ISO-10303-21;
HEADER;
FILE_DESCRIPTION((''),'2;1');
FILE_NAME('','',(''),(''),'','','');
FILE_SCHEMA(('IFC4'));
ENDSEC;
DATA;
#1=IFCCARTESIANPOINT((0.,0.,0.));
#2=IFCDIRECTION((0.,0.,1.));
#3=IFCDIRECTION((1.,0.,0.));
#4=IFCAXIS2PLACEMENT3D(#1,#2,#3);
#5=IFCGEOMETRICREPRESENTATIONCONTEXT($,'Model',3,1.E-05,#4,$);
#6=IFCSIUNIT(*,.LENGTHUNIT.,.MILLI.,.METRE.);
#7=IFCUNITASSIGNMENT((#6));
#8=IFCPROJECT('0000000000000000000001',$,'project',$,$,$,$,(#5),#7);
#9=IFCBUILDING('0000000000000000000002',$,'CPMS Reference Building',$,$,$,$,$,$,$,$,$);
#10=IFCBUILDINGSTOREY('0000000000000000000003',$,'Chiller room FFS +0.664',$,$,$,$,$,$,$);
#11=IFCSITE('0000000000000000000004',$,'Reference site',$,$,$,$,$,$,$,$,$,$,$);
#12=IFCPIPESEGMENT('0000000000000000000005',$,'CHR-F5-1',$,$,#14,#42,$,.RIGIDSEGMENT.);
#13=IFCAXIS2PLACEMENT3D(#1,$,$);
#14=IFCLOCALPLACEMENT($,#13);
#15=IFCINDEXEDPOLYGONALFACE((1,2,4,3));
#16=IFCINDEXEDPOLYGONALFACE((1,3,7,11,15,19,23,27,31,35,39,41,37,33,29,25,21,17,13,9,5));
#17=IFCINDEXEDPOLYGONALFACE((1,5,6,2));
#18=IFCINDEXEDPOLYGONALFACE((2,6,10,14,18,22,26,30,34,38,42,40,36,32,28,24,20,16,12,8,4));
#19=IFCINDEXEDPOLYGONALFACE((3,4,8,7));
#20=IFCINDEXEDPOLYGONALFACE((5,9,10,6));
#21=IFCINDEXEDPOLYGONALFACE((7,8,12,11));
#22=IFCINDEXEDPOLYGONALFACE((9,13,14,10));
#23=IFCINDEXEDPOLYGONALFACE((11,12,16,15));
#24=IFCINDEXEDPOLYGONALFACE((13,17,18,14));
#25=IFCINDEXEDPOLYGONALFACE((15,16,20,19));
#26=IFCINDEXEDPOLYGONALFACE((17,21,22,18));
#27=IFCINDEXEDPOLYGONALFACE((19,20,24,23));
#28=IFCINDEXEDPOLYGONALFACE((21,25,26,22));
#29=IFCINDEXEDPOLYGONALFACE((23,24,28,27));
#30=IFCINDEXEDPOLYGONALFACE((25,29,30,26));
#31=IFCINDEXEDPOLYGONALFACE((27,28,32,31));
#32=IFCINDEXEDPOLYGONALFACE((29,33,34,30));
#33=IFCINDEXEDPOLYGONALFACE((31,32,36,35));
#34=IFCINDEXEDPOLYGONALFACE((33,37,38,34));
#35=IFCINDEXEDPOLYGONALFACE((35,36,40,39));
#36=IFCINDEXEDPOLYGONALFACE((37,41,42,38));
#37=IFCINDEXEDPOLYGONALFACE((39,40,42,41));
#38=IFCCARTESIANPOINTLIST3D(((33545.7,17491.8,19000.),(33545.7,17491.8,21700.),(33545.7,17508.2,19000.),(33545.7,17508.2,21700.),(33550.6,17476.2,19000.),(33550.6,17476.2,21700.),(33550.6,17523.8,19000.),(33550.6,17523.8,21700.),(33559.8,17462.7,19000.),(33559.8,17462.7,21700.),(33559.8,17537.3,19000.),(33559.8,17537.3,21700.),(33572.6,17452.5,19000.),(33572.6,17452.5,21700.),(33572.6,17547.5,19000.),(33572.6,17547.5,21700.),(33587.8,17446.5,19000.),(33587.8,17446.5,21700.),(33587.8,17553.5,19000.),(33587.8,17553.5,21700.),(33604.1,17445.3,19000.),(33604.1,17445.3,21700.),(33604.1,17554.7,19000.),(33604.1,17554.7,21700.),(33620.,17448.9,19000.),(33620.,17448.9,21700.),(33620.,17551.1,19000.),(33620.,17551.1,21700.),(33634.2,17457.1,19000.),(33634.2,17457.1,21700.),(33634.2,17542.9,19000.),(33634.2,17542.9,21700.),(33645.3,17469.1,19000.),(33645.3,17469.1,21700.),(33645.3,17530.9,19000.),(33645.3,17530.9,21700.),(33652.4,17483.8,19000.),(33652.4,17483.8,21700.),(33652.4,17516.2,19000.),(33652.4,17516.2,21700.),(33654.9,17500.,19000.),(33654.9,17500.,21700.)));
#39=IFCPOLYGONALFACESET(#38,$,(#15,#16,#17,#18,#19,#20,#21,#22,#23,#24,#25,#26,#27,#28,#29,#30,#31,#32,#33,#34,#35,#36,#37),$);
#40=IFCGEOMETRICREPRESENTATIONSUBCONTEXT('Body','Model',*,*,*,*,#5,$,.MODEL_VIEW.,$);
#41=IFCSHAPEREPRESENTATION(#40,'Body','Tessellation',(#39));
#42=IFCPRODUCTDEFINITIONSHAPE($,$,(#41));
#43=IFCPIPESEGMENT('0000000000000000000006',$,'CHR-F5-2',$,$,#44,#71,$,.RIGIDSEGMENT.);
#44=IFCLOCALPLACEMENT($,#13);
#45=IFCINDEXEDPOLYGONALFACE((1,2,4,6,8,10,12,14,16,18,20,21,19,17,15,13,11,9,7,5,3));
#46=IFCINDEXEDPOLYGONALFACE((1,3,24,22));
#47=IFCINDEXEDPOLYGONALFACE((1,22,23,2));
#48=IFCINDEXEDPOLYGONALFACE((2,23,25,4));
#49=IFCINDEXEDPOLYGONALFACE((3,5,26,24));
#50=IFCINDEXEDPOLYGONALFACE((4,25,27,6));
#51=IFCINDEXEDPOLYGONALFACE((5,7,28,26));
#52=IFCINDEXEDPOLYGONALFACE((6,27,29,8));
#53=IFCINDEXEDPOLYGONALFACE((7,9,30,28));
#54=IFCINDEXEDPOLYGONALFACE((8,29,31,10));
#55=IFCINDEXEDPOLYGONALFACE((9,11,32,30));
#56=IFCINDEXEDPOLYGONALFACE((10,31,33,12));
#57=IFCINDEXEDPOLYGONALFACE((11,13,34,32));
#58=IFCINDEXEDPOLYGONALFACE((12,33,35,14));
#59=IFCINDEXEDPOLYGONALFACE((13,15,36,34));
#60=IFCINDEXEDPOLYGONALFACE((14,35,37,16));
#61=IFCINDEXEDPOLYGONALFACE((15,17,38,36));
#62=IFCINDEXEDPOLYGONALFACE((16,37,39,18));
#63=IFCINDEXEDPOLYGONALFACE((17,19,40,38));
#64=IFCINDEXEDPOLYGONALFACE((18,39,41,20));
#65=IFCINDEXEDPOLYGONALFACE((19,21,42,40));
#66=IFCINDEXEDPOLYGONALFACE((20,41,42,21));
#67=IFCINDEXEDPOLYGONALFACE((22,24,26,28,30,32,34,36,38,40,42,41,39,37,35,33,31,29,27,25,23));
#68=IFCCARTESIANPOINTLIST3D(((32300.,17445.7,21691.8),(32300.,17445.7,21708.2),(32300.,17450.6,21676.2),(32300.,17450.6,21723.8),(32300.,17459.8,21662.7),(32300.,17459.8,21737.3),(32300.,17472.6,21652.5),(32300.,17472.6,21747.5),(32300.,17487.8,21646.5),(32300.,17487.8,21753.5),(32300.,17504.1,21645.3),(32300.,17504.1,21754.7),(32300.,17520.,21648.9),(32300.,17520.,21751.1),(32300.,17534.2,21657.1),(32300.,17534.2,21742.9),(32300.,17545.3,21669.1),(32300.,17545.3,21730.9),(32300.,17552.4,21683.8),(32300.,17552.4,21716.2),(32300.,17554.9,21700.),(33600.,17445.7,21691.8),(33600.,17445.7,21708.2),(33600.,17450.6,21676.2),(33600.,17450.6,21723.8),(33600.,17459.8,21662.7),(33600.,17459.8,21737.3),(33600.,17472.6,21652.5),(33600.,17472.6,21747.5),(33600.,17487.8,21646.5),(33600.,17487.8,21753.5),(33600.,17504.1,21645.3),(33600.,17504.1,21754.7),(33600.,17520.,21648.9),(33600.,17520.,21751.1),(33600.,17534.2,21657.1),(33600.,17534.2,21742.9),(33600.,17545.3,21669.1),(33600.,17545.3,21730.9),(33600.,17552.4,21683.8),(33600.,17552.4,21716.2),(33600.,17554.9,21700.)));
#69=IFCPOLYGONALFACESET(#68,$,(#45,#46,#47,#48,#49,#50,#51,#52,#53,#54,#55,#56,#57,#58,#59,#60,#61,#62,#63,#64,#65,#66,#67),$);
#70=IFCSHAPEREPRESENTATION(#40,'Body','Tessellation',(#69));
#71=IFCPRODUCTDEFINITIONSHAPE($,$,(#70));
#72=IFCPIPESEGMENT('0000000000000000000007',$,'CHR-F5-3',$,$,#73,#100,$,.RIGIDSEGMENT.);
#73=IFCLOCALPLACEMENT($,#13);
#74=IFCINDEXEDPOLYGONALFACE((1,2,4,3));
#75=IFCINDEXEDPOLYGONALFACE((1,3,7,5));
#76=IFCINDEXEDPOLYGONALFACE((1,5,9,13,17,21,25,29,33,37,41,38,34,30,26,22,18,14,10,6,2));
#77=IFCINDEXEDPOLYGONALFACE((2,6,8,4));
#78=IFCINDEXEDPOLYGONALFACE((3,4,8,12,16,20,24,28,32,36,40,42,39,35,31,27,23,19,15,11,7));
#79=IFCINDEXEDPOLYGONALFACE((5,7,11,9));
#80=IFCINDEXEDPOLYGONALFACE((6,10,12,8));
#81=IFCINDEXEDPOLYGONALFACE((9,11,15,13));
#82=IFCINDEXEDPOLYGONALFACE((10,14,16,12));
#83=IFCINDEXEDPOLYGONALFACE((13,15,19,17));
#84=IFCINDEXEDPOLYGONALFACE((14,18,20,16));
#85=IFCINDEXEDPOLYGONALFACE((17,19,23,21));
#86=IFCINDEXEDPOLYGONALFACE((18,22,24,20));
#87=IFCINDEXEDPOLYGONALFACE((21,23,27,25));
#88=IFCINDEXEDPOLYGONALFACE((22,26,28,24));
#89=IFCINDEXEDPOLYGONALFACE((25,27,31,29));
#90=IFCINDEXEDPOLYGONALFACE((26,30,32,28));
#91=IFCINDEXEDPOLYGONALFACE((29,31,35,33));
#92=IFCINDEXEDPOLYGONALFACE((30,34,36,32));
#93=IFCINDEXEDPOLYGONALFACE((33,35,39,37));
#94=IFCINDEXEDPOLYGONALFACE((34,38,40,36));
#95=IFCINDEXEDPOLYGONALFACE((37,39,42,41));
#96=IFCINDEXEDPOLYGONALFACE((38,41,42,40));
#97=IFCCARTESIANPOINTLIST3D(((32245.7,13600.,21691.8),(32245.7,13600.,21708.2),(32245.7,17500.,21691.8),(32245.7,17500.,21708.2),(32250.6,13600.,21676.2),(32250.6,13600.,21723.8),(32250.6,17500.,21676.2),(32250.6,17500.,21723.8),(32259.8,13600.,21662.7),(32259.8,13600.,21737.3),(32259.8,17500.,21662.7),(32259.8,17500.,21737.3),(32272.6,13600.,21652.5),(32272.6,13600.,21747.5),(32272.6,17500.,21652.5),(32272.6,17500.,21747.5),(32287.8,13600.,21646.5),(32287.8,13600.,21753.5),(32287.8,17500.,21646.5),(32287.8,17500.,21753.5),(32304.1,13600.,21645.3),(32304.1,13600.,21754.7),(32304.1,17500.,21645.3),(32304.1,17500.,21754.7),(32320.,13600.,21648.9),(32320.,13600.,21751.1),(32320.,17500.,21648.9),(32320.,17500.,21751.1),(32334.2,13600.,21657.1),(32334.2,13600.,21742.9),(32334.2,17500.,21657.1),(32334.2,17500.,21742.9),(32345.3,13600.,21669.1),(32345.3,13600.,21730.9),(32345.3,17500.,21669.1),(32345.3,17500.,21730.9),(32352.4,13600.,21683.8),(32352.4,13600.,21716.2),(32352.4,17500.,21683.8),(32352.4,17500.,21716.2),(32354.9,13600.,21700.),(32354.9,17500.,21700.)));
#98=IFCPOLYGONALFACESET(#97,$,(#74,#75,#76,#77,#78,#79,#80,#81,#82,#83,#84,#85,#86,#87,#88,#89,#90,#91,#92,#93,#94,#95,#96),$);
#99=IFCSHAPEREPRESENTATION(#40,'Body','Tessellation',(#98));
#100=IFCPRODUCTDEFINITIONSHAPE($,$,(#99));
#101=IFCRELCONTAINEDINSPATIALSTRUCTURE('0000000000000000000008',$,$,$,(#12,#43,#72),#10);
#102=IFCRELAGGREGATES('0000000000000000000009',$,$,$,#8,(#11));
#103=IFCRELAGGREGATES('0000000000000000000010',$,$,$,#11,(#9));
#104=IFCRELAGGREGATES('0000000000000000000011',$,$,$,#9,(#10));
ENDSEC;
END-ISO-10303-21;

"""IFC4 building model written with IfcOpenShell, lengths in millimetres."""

from ifc_helpers import new_model, si_unit, frame, origin_with_axes, origin_2d, place, context, subcontext, project, spatial, circle_curve, outline, extrude, element, save


model = new_model("IFC4")

# Units and contexts
model_context = context("Model", 3, precision=1e-05, world=origin_with_axes())
body_context = subcontext(model_context, "Body", "Model", "MODEL_VIEW")
ifc_project = project(units=[si_unit("LENGTHUNIT", "METRE", prefix="MILLI")], contexts=[model_context])

# Site, building, storey
site = spatial("IfcSite", under=ifc_project, Name="Reference site")
building = spatial("IfcBuilding", under=site, Name="CPMS Reference Building")
storey = spatial("IfcBuildingStorey", under=building, Name="Chiller room FFS +0.664")

# Pipe segments
pipe_segment_1_placement = place(None, origin_with_axes())
element("IfcPipeSegment", 1, at=pipe_segment_1_placement, inside=storey, Name="CHR-F5-1", PredefinedType="RIGIDSEGMENT", context=body_context, shape_type="SweptSolid", body=[
    extrude(outline(circle_curve(origin_2d(), 54.9)), frame((33600.0, 17500.0, 19000.0), z_axis=(0.0, 0.0, 1.0), x_axis=(1.0, 0.0, 0.0)), (0.0, 0.0, 1.0), 2700.0),
])
pipe_segment_2_placement = place(None, origin_with_axes())
element("IfcPipeSegment", 2, at=pipe_segment_2_placement, inside=storey, Name="CHR-F5-2", PredefinedType="RIGIDSEGMENT", context=body_context, shape_type="SweptSolid", body=[
    extrude(outline(circle_curve(origin_2d(), 54.9)), frame((33600.0, 17500.0, 21700.0), z_axis=(-1.0, 0.0, 0.0), x_axis=(0.0, 1.0, 0.0)), (0.0, 0.0, 1.0), 1300.0),
])
pipe_segment_3_placement = place(None, origin_with_axes())
element("IfcPipeSegment", 3, at=pipe_segment_3_placement, inside=storey, Name="CHR-F5-3", PredefinedType="RIGIDSEGMENT", context=body_context, shape_type="SweptSolid", body=[
    extrude(outline(circle_curve(origin_2d(), 54.9)), frame((32300.0, 17500.0, 21700.0), z_axis=(0.0, -1.0, 0.0), x_axis=(1.0, 0.0, 0.0)), (0.0, 0.0, 1.0), 3900.0),
])

save(model, "model.ifc")
